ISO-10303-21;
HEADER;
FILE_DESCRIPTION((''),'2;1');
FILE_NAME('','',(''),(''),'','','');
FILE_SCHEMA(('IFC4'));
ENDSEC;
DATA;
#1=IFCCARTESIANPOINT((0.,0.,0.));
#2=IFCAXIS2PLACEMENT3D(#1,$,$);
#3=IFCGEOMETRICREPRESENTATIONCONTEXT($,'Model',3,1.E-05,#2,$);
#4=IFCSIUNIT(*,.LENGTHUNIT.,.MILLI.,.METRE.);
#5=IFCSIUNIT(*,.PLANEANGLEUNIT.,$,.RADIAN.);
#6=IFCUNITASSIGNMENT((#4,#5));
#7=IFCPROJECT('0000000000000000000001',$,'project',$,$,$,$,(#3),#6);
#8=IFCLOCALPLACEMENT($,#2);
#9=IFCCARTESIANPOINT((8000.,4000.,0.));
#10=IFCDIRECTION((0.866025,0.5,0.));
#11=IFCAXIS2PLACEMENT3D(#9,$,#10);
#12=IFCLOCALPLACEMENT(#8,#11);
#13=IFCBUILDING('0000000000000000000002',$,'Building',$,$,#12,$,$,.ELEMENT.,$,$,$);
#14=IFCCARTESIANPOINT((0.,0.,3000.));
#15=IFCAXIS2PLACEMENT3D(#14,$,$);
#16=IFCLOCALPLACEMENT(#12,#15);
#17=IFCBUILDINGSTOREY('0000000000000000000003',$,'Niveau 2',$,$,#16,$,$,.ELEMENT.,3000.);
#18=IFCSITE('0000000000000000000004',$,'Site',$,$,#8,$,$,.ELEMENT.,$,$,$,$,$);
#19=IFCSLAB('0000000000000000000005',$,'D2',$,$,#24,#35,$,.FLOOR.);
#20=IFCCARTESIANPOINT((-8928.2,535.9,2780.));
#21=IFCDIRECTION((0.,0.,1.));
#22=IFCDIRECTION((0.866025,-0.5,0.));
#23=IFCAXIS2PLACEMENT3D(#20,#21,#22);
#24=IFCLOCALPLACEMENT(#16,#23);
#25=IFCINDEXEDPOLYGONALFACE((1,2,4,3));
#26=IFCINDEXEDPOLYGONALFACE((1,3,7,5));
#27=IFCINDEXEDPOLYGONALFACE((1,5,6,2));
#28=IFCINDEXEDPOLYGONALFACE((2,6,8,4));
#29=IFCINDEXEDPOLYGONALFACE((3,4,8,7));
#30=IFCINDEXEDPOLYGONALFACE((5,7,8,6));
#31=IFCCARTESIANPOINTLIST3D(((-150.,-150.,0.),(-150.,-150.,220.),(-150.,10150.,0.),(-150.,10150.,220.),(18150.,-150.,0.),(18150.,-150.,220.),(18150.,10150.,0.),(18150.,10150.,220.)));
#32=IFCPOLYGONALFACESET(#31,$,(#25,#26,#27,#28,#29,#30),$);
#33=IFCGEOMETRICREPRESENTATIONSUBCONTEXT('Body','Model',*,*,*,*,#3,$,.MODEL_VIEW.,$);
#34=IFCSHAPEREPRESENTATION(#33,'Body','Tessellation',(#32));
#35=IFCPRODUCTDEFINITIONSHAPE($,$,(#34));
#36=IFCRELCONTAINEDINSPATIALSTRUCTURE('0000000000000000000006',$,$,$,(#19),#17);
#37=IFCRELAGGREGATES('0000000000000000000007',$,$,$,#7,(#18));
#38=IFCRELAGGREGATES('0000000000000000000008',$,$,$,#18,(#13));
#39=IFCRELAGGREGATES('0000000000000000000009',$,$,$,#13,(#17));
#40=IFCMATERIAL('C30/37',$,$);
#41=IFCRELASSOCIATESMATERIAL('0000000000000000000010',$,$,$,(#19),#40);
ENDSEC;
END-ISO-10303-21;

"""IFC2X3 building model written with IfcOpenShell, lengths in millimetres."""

from ifc_helpers import new_model, si_unit, frame, origin, place, context, subcontext, project, spatial, polyline, outline, extrude, material, element, save


model = new_model("IFC2X3")

# Units and contexts
model_context = context("Model", 3, precision=1e-05, world=origin())
body_context = subcontext(model_context, "Body", "Model", "MODEL_VIEW")
ifc_project = project(units=[si_unit("LENGTHUNIT", "METRE", prefix="MILLI"), si_unit("PLANEANGLEUNIT", "RADIAN")], contexts=[model_context])

# Site, building, storey
site_placement = place(None, origin())
site = spatial("IfcSite", under=ifc_project, at=site_placement, Name="Site", CompositionType="ELEMENT")
building_placement = place(site_placement, frame((8000.0, 4000.0, 0.0), x_axis=(0.866025, 0.5, 0.0)))
building = spatial("IfcBuilding", under=site, at=building_placement, Name="Building", CompositionType="ELEMENT")
storey_placement = place(building_placement, frame((0.0, 0.0, 3000.0)))
storey = spatial("IfcBuildingStorey", under=building, at=storey_placement, Name="Niveau 2", CompositionType="ELEMENT", Elevation=3000.0)

# Shared definitions
ifc_material = material(Name="C30/37")

# Slab
slab_placement = place(storey_placement, frame((-8928.2, 535.9, 2780.0), z_axis=(0.0, 0.0, 1.0), x_axis=(0.866025, -0.5, 0.0)))
element("IfcSlab", 1, at=slab_placement, inside=storey, material=ifc_material, Name="D2", PredefinedType="FLOOR", context=body_context, shape_type="SweptSolid", body=[
    extrude(outline(polyline([(-150.0, -150.0), (18150.0, -150.0), (18150.0, 10150.0), (-150.0, 10150.0), (-150.0, -150.0)])), origin(), (0.0, 0.0, 1.0), 220.0),
])

save(model, "model.ifc")
